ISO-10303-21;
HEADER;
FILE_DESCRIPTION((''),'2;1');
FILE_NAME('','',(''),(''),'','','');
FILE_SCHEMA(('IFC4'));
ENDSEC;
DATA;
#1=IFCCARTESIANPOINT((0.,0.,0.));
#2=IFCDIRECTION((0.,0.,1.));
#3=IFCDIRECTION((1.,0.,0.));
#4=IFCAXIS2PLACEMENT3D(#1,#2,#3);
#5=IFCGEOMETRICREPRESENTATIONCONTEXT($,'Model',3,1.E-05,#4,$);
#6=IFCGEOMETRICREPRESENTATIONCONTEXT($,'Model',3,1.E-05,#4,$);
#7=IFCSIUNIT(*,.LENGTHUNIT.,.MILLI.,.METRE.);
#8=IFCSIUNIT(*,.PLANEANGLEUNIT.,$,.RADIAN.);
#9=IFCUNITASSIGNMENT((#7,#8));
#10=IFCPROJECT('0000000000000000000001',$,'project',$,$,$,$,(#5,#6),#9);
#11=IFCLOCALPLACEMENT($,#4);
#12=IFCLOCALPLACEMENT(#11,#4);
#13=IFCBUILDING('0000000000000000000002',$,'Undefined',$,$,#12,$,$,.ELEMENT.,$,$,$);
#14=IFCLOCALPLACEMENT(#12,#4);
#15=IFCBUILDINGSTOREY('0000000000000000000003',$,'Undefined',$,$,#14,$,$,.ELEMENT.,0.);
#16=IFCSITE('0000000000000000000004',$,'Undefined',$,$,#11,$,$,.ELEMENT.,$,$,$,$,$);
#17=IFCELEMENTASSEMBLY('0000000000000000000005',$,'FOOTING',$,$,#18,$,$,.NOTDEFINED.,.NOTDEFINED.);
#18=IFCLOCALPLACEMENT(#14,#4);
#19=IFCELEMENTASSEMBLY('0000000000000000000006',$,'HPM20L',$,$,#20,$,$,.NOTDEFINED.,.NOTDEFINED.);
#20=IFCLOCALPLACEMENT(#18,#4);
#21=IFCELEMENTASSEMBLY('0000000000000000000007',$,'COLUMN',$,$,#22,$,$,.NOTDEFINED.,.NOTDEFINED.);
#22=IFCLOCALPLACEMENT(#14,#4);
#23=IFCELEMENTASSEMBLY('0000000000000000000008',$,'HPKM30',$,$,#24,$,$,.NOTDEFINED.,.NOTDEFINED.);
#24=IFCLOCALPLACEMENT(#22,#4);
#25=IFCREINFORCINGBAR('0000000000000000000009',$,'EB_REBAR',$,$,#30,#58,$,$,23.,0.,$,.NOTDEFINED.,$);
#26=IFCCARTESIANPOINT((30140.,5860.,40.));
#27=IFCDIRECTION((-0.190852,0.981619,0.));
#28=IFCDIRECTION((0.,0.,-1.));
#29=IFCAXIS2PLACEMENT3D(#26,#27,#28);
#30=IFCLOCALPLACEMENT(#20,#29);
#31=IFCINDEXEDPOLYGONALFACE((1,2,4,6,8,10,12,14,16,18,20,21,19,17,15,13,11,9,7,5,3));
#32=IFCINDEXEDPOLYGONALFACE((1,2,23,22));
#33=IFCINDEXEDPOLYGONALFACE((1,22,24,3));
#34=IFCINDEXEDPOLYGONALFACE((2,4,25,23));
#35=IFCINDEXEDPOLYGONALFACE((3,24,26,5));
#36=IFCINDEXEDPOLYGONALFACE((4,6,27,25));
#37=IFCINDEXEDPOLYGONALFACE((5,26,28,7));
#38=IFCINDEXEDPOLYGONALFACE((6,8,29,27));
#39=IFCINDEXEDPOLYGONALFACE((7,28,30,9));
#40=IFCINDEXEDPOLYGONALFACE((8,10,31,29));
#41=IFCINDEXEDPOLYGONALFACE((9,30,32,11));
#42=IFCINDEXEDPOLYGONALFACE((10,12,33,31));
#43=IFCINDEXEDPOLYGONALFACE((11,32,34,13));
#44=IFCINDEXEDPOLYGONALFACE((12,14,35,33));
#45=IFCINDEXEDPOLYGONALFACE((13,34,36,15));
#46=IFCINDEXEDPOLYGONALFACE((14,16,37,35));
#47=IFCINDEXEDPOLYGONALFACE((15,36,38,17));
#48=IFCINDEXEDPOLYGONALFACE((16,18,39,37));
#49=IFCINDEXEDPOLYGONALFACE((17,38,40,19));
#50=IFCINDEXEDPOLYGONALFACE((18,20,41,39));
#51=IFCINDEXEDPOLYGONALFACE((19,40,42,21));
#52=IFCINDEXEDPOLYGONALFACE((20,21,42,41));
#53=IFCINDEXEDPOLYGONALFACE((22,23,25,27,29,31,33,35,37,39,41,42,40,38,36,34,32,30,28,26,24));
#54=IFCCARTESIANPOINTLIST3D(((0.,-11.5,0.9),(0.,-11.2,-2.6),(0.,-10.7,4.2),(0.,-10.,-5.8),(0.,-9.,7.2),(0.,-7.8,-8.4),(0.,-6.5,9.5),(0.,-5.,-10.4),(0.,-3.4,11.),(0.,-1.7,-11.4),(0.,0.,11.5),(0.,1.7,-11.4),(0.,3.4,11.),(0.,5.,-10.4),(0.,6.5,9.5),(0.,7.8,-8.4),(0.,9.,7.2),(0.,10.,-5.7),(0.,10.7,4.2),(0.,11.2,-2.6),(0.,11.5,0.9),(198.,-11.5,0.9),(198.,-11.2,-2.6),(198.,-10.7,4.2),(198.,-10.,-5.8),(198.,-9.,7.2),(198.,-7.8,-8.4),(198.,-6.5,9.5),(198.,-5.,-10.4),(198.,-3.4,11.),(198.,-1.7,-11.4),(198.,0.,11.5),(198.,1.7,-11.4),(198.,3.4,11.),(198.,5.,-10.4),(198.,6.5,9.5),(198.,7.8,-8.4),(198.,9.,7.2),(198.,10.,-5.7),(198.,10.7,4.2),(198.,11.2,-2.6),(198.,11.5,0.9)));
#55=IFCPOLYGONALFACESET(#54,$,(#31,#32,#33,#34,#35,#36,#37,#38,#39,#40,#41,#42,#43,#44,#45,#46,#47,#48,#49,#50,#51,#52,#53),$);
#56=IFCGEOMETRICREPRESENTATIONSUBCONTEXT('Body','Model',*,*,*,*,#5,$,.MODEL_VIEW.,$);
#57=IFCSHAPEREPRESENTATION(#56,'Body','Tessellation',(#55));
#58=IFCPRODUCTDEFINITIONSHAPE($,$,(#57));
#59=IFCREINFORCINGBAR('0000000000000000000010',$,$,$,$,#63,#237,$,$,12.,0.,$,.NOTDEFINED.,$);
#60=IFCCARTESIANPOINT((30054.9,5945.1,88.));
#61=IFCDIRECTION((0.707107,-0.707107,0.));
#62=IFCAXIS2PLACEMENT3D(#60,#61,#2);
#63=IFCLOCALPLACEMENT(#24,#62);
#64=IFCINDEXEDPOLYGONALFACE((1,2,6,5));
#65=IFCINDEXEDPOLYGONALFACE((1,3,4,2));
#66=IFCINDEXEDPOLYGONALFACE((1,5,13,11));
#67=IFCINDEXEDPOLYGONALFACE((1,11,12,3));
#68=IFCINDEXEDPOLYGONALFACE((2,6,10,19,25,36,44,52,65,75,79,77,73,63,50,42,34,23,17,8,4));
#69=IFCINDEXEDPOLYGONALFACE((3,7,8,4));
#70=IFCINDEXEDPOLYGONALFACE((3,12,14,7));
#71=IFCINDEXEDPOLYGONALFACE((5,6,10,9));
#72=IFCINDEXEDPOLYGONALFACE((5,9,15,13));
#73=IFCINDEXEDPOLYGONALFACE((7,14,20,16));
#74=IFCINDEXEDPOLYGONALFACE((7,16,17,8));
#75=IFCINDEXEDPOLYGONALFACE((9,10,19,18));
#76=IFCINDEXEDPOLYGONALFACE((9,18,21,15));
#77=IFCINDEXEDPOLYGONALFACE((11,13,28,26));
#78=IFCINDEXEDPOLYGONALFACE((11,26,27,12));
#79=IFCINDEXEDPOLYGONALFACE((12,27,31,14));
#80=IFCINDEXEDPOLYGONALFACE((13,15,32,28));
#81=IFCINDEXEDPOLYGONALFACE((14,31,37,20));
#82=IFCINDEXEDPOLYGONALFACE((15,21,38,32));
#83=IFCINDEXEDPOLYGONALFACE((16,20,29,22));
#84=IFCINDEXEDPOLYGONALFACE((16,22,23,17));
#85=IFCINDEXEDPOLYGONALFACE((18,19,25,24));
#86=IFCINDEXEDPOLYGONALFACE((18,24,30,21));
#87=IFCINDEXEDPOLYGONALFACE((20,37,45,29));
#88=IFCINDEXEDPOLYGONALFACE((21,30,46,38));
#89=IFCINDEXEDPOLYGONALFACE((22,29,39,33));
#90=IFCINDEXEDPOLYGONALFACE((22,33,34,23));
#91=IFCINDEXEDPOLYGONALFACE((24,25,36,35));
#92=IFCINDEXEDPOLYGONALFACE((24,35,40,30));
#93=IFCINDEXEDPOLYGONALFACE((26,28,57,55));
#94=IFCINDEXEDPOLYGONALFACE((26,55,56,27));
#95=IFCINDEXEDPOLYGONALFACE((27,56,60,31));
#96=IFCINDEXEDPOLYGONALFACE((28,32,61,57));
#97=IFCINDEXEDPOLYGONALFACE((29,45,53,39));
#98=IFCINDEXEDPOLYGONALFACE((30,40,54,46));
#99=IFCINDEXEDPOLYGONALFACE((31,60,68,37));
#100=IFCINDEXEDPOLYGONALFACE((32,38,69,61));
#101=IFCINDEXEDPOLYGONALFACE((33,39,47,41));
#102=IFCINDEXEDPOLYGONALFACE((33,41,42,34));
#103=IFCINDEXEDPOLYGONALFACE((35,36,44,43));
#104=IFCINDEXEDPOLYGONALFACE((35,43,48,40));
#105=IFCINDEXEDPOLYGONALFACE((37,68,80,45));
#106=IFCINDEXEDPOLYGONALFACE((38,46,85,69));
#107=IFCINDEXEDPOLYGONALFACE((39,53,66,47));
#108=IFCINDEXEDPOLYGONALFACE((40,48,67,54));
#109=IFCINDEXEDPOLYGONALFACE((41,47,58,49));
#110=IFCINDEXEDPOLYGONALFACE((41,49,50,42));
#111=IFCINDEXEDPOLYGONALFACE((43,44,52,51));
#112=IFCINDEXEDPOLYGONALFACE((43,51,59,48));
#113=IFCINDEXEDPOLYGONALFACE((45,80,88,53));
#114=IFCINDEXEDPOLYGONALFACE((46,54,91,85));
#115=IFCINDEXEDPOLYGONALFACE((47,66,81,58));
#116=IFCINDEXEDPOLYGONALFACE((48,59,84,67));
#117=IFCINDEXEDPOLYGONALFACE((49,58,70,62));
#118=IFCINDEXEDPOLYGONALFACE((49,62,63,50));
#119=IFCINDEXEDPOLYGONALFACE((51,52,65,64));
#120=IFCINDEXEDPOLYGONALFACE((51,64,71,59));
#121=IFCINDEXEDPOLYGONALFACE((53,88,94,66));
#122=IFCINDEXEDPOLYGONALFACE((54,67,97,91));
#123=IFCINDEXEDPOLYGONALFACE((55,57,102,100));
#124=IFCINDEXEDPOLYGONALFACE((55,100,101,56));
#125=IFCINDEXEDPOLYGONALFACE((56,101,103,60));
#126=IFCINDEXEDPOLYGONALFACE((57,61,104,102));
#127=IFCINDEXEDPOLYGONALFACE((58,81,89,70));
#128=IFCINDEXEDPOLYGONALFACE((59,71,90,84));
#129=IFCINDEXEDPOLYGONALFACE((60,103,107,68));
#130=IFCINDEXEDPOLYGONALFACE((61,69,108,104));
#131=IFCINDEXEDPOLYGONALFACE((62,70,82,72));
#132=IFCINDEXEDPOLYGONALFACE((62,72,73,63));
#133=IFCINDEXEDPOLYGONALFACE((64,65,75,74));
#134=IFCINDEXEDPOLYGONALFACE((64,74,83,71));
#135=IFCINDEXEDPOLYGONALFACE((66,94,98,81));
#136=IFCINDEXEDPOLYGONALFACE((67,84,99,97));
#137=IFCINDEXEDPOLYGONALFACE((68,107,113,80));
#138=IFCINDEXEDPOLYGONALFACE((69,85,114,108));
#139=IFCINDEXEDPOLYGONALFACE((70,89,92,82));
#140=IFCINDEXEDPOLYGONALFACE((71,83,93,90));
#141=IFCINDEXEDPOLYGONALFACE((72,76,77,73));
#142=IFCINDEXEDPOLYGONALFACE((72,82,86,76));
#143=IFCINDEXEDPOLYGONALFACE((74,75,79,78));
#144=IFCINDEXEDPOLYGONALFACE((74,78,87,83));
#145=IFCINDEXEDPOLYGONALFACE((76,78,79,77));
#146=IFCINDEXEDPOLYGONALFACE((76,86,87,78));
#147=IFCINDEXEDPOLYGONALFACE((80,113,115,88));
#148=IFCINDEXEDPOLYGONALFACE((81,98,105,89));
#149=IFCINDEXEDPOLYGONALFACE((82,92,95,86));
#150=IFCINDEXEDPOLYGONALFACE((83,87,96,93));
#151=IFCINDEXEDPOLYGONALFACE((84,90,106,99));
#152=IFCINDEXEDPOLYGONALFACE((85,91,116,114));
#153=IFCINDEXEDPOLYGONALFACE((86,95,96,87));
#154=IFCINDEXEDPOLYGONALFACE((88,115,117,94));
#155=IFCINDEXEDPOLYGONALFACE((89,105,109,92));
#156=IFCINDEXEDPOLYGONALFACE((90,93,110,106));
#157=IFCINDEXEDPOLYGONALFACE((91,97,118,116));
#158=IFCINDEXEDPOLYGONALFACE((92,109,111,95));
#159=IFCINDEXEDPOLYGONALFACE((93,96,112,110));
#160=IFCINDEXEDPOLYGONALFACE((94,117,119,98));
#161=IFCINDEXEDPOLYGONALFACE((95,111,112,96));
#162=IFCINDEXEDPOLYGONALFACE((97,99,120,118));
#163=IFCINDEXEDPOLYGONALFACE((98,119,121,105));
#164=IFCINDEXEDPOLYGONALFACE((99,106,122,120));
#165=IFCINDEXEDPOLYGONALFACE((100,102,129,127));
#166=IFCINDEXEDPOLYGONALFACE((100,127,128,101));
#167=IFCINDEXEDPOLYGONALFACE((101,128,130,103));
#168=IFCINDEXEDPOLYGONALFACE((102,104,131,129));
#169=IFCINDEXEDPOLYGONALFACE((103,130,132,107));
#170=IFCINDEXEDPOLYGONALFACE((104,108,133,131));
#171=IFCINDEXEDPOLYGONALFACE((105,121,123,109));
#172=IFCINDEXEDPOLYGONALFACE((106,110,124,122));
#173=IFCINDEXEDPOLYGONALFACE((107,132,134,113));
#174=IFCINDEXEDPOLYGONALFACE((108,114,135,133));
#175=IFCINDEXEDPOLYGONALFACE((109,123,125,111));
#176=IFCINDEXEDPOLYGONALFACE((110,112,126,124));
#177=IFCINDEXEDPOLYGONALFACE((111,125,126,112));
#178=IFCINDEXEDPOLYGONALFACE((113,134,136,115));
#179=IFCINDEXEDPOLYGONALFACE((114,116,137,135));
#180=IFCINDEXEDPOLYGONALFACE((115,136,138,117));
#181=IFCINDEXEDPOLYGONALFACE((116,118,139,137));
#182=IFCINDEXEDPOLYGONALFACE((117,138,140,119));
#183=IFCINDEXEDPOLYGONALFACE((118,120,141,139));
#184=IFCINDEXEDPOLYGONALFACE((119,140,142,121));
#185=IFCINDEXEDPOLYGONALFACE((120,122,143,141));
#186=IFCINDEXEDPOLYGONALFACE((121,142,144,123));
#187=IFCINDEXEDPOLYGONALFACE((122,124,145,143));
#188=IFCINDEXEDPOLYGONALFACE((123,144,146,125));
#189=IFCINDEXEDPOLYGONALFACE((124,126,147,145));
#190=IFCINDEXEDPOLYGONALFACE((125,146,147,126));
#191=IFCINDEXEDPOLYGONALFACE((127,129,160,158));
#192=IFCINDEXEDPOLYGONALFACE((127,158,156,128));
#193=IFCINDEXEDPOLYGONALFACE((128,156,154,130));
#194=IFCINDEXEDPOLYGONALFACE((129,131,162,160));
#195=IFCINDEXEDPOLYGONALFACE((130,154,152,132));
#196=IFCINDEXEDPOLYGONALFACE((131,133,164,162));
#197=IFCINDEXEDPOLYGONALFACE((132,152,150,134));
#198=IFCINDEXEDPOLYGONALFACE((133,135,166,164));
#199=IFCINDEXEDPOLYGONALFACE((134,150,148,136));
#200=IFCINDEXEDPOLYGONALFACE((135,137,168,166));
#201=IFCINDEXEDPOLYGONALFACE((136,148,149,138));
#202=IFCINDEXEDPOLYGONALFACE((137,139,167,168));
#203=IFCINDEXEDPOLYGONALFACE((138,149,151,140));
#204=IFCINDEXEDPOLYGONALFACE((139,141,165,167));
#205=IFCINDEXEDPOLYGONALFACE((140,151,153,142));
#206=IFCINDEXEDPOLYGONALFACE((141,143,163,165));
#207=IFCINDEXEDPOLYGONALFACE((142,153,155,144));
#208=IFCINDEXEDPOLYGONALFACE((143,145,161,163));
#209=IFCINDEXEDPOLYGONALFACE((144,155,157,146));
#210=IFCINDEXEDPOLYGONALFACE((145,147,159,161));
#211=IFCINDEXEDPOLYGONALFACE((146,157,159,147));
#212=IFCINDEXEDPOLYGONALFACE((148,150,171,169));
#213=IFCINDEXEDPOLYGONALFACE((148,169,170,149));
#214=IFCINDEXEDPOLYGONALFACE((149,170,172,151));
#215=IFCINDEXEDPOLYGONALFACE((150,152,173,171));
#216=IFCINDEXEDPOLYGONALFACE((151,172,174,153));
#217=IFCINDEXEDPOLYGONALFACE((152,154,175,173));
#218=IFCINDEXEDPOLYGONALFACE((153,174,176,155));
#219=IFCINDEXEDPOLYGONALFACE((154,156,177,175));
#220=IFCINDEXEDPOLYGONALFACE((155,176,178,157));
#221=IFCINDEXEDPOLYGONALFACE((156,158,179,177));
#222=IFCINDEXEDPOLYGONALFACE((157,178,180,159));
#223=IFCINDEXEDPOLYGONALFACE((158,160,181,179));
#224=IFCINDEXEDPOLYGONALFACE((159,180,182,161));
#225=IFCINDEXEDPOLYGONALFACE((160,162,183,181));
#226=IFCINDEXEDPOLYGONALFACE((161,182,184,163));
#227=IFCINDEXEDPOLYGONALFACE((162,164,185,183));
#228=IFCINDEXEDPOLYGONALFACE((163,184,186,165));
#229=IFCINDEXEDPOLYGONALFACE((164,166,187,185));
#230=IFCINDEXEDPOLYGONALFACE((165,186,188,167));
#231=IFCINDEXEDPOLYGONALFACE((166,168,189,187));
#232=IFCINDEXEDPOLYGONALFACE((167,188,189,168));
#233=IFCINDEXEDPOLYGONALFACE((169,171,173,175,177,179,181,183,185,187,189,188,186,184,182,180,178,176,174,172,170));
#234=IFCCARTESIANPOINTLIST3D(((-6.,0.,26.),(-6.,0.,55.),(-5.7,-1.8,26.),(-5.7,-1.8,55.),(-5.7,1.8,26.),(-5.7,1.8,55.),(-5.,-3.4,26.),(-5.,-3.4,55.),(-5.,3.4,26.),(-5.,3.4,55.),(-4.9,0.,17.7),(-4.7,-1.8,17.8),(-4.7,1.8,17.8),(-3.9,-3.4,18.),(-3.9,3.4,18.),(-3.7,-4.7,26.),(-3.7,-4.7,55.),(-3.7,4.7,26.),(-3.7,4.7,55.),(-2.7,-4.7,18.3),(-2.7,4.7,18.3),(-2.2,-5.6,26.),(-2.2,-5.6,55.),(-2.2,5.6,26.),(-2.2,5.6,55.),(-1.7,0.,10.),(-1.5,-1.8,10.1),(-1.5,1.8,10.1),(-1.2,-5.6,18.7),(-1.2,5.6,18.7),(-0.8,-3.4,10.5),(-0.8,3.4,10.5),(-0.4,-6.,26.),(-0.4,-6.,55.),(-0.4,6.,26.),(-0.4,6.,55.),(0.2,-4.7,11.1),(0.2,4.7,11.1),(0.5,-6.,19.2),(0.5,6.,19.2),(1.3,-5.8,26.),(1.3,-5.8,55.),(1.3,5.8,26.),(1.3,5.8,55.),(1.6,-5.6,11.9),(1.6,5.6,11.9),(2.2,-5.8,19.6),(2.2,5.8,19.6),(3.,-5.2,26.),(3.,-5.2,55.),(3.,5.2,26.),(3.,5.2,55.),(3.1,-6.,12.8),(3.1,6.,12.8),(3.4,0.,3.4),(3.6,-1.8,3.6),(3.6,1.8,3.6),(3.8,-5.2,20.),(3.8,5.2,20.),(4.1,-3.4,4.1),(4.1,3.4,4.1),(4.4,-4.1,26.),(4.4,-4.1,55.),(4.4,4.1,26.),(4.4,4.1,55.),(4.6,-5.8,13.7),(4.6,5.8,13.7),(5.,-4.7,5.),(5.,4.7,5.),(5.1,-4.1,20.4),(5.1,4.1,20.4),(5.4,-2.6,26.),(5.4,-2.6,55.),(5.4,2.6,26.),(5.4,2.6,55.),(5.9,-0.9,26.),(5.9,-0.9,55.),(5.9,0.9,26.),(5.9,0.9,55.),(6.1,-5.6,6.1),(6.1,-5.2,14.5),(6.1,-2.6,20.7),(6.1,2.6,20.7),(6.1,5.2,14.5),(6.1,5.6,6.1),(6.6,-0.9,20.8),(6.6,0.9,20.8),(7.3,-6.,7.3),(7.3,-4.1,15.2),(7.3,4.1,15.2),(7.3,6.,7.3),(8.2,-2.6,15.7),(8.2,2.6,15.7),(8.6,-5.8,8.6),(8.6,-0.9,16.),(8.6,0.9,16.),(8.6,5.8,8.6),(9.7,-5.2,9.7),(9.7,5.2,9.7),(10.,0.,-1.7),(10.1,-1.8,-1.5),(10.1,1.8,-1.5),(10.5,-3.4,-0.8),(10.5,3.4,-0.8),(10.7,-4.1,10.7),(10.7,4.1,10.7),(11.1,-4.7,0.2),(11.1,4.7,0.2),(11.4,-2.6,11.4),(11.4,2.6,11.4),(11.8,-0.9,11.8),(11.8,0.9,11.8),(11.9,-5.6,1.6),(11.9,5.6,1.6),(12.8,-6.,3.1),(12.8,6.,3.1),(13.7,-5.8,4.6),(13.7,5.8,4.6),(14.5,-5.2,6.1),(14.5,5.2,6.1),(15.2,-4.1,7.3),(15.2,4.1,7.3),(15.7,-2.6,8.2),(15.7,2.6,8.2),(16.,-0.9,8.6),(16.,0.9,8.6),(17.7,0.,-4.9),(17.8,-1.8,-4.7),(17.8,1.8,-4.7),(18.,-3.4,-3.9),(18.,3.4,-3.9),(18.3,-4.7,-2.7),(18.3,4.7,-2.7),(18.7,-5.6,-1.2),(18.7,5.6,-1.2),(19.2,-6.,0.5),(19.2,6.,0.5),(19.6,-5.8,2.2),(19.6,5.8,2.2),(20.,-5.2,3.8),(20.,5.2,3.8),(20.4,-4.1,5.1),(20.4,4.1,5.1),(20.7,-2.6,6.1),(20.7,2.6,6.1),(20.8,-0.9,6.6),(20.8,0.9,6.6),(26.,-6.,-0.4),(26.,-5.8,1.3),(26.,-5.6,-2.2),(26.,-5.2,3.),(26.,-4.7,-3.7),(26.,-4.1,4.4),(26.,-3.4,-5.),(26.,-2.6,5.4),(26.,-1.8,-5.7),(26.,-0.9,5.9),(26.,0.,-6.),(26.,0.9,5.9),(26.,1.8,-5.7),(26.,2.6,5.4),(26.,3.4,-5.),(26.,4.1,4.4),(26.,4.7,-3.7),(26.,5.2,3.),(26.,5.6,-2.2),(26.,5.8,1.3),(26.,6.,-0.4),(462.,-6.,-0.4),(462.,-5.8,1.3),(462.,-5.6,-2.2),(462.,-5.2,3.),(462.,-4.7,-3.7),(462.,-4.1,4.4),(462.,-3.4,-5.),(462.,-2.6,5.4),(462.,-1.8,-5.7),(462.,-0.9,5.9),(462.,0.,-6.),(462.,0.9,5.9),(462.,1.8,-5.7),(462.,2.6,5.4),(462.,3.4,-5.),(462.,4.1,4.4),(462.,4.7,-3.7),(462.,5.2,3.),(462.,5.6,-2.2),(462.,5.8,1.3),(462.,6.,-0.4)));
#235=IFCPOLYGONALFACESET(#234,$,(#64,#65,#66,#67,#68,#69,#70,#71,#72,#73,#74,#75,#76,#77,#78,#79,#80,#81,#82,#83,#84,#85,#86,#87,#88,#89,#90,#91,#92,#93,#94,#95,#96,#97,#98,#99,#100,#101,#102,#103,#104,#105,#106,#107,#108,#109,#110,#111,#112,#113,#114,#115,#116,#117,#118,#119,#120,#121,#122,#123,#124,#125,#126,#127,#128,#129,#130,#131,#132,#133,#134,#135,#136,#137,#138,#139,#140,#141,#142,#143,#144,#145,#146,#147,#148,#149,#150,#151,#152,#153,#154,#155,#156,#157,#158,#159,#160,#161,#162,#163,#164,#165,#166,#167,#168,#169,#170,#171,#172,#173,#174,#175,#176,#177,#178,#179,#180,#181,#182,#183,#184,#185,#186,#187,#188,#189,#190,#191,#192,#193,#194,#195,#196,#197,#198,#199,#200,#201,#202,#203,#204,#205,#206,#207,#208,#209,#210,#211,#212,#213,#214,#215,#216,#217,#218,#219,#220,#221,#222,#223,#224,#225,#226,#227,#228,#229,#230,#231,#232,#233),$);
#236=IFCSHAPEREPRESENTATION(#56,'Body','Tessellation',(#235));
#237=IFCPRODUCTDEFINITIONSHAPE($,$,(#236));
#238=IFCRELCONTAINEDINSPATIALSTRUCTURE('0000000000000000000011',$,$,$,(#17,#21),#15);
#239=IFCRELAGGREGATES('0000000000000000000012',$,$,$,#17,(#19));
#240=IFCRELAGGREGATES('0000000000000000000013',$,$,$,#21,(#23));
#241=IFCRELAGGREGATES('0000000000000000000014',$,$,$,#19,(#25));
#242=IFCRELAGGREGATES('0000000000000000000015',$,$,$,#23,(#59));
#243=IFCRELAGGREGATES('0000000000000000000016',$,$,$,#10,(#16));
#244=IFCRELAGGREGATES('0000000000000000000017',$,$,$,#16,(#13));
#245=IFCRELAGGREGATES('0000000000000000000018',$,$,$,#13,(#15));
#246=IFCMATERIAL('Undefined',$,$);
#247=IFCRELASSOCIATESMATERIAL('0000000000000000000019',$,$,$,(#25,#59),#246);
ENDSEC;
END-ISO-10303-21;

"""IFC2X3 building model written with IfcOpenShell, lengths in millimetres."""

from ifc_helpers import new_model, entity, si_unit, frame, origin_with_axes, place, context, subcontext, project, spatial, source, transform, mapped, material, element, aggregate, save


model = new_model("IFC2X3")

# Units and contexts
model_context_1 = context("Model", 3, precision=1e-05, world=origin_with_axes())
model_context_2 = context("Model", 3, precision=1e-05, world=origin_with_axes())
body_context = subcontext(model_context_1, "Body", "Model", "MODEL_VIEW")
ifc_project = project(units=[si_unit("LENGTHUNIT", "METRE", prefix="MILLI"), si_unit("PLANEANGLEUNIT", "RADIAN")], contexts=[model_context_1, model_context_2])

# Site, building, storey
site_placement = place(None, origin_with_axes())
site = spatial("IfcSite", under=ifc_project, at=site_placement, Name="Undefined", CompositionType="ELEMENT")
building_placement = place(site_placement, origin_with_axes())
building = spatial("IfcBuilding", under=site, at=building_placement, Name="Undefined", CompositionType="ELEMENT")
storey_placement = place(building_placement, origin_with_axes())
storey = spatial("IfcBuildingStorey", under=building, at=storey_placement, Name="Undefined", CompositionType="ELEMENT", Elevation=0.0)

# Element assemblies
assembly_1_placement = place(storey_placement, origin_with_axes())
assembly_1 = element("IfcElementAssembly", 1, at=assembly_1_placement, inside=storey, Name="FOOTING", AssemblyPlace="NOTDEFINED", PredefinedType="NOTDEFINED")
assembly_2_placement = place(assembly_1_placement, origin_with_axes())
assembly_2 = element("IfcElementAssembly", 2, at=assembly_2_placement, Name="HPM20L", AssemblyPlace="NOTDEFINED", PredefinedType="NOTDEFINED")
aggregate(assembly_1, [assembly_2])

# Element assemblies
assembly_3_placement = place(storey_placement, origin_with_axes())
assembly_3 = element("IfcElementAssembly", 3, at=assembly_3_placement, inside=storey, Name="COLUMN", AssemblyPlace="NOTDEFINED", PredefinedType="NOTDEFINED")
assembly_4_placement = place(assembly_3_placement, origin_with_axes())
assembly_4 = element("IfcElementAssembly", 4, at=assembly_4_placement, Name="HPKM30", AssemblyPlace="NOTDEFINED", PredefinedType="NOTDEFINED")
aggregate(assembly_3, [assembly_4])

# Shared definitions
ifc_material_1 = material(Name="Undefined")

# Reinforcing bars
shared_shape_1 = source(origin_with_axes(), body_context, "Body", "AdvancedSweptSolid", [
    entity("IfcSweptDiskSolid", entity("IfcTrimmedCurve", entity("IfcLine", entity("IfcCartesianPoint", [0.0, 0.0, 0.0]), entity("IfcVector", entity("IfcDirection", [1.0, 0.0, 0.0]), 1.0)), [entity("IfcParameterValue", 0.0)], [entity("IfcParameterValue", 198.0)], True, "PARAMETER"), 11.5, None, 0.0, 198.0),
])
reinforcing_bar_1_placement = place(assembly_2_placement, frame((30140.0, 5860.0, 40.0), z_axis=(-0.190852, 0.981619, 0.0), x_axis=(0.0, 0.0, -1.0)))
reinforcing_bar_1 = element("IfcReinforcingBar", 5, at=reinforcing_bar_1_placement, material=ifc_material_1, Name="EB_REBAR", BarRole="NOTDEFINED", CrossSectionArea=0.0, NominalDiameter=23.0, context=body_context, shape_type="MappedRepresentation", body=[
    mapped(shared_shape_1, transform((0.0, 0.0, 0.0))),
])
aggregate(assembly_2, [reinforcing_bar_1])
shared_shape_2 = source(origin_with_axes(), body_context, "Body", "AdvancedSweptSolid", [
    entity("IfcSweptDiskSolid", entity("IfcCompositeCurve", [entity("IfcCompositeCurveSegment", "CONTINUOUS", True, entity("IfcTrimmedCurve", entity("IfcLine", entity("IfcCartesianPoint", [0.0, 0.0, 0.0]), entity("IfcVector", entity("IfcDirection", [0.0, 0.0, -1.0]), 1.0)), [entity("IfcParameterValue", 0.0)], [entity("IfcParameterValue", 29.0)], True, "PARAMETER")), entity("IfcCompositeCurveSegment", "CONTINUOUS", True, entity("IfcTrimmedCurve", entity("IfcCircle", entity("IfcAxis2Placement3D", entity("IfcCartesianPoint", [26.0, 0.0, -29.0]), entity("IfcDirection", [0.0, -1.0, 0.0]), entity("IfcDirection", [-1.0, 0.0, 0.0])), 26.0), [entity("IfcParameterValue", 0.0)], [entity("IfcParameterValue", 1.570796)], True, "PARAMETER")), entity("IfcCompositeCurveSegment", "DISCONTINUOUS", True, entity("IfcTrimmedCurve", entity("IfcLine", entity("IfcCartesianPoint", [26.0, 0.0, -55.0]), entity("IfcVector", entity("IfcDirection", [1.0, 0.0, 0.0]), 1.0)), [entity("IfcParameterValue", 0.0)], [entity("IfcParameterValue", 436.0)], True, "PARAMETER"))], False), 6.0, None, 0.0, 466.6),
])
reinforcing_bar_2_placement = place(assembly_4_placement, frame((30054.9, 5945.1, 88.0), z_axis=(0.707107, -0.707107, 0.0), x_axis=(0.0, 0.0, 1.0)))
reinforcing_bar_2 = element("IfcReinforcingBar", 6, at=reinforcing_bar_2_placement, material=ifc_material_1, BarRole="NOTDEFINED", CrossSectionArea=0.0, NominalDiameter=12.0, context=body_context, shape_type="MappedRepresentation", body=[
    mapped(shared_shape_2, transform((0.0, 0.0, 55.0))),
])
aggregate(assembly_4, [reinforcing_bar_2])

save(model, "model.ifc")
